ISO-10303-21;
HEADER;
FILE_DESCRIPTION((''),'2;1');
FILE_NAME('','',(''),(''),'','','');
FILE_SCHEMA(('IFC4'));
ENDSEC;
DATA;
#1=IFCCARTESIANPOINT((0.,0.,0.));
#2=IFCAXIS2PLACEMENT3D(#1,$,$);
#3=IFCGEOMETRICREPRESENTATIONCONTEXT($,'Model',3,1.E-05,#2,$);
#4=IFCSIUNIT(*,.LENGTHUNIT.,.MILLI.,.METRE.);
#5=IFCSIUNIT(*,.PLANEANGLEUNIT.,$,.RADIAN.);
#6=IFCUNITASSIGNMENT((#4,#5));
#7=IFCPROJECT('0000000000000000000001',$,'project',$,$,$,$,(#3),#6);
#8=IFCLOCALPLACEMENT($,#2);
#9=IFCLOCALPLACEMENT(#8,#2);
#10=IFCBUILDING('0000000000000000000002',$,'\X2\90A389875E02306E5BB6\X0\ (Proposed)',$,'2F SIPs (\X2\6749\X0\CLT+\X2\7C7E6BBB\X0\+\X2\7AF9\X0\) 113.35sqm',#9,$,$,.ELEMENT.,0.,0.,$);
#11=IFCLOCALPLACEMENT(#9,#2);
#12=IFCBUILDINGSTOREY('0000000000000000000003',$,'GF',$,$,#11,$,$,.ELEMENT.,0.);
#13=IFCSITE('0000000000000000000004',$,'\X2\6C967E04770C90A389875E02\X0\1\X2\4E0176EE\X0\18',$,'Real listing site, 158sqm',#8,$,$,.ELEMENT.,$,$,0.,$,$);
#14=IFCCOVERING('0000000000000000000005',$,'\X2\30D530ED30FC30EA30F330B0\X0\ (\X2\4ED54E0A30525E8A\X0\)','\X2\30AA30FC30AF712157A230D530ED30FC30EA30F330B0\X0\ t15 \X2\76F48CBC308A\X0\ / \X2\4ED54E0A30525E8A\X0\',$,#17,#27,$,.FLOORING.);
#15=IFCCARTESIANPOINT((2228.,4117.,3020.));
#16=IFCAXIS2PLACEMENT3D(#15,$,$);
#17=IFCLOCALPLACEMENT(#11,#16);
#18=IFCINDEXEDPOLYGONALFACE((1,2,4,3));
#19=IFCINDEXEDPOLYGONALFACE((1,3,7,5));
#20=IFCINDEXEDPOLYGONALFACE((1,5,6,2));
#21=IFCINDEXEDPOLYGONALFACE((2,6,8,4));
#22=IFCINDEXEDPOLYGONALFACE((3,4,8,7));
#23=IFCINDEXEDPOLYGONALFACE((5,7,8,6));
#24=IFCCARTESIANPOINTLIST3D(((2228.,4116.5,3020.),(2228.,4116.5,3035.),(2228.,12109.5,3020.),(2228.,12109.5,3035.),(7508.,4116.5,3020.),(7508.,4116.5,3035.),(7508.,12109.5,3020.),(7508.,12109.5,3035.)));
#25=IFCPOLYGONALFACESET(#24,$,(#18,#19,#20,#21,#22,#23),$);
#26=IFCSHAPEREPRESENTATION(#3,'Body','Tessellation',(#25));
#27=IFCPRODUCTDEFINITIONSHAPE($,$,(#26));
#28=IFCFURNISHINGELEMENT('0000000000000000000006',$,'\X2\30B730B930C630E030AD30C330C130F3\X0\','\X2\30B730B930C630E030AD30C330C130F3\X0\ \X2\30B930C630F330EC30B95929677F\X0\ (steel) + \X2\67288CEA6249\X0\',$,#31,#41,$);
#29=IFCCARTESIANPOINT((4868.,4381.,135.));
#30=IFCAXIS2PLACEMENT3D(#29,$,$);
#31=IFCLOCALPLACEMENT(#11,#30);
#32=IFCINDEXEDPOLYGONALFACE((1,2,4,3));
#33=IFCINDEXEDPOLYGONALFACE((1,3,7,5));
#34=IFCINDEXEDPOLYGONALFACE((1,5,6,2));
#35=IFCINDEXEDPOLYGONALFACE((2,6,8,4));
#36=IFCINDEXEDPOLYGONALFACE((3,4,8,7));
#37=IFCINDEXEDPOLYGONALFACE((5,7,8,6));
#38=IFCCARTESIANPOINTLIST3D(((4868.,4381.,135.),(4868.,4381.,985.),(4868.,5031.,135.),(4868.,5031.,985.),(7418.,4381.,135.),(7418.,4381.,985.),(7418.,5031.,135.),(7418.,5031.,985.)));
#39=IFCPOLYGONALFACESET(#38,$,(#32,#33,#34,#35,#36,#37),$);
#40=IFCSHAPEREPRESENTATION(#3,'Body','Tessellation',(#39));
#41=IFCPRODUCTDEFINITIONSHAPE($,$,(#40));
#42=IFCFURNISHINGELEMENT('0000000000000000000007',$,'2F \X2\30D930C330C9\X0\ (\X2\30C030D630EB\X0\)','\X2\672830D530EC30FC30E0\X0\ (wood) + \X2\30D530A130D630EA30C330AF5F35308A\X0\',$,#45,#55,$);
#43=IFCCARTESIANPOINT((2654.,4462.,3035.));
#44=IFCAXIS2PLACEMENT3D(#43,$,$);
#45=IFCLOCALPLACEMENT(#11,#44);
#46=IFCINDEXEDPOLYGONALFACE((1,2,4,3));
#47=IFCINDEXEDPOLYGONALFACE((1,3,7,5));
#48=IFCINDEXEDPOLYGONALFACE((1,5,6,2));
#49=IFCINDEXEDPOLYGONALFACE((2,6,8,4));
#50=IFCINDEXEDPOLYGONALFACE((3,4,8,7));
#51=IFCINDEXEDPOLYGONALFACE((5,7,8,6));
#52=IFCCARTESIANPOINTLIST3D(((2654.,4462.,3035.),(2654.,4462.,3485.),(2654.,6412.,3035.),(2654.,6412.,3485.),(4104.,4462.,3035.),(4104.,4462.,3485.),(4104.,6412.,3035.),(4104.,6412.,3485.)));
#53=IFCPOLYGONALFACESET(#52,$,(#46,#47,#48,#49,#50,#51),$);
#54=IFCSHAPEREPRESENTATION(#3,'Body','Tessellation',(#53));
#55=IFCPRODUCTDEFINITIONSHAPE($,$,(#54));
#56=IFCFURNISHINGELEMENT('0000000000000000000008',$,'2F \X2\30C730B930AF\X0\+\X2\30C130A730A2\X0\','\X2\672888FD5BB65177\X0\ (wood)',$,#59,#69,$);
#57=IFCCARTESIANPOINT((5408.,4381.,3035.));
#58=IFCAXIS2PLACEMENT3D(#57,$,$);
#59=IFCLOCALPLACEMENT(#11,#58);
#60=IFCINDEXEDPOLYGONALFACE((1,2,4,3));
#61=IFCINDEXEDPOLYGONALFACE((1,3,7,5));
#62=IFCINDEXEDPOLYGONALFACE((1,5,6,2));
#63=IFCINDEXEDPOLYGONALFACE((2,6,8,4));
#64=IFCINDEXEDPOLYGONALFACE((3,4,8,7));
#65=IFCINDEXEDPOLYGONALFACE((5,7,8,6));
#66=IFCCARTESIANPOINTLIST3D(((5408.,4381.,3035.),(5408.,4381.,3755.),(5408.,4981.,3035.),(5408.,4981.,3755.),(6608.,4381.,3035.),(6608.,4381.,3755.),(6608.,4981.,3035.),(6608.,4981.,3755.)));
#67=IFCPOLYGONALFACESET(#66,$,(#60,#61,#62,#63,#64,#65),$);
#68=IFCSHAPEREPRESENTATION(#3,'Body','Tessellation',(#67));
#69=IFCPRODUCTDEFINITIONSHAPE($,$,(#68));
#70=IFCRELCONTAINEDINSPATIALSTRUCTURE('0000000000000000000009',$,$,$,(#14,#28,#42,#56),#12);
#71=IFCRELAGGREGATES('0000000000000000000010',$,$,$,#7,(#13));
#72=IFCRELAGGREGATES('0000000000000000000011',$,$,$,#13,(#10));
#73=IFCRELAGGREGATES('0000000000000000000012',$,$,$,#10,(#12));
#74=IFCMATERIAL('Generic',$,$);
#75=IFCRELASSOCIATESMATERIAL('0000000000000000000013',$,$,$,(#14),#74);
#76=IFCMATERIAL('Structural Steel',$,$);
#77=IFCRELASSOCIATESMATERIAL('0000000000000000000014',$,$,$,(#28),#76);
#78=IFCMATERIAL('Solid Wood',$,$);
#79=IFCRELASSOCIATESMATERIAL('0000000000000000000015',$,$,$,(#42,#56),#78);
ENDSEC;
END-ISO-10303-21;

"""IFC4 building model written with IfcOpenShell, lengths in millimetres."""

from ifc_helpers import new_model, si_unit, frame, frame_2d, origin, place, context, project, spatial, rectangle, extrude, material, element, save


model = new_model("IFC4")

# Units and contexts
model_context = context("Model", 3, precision=1e-05, world=origin())
ifc_project = project(units=[si_unit("LENGTHUNIT", "METRE", prefix="MILLI"), si_unit("PLANEANGLEUNIT", "RADIAN")], contexts=[model_context])

# Site, building, storey
site_placement = place(None, origin())
site = spatial("IfcSite", under=ifc_project, at=site_placement, Name="沖縄県那覇市1丁目18", ObjectType="Real listing site, 158sqm", CompositionType="ELEMENT", RefElevation=0.0)
building_placement = place(site_placement, origin())
building = spatial("IfcBuilding", under=site, at=building_placement, Name="那覇市の家 (Proposed)", ObjectType="2F SIPs (杉CLT+籾殻+竹) 113.35sqm", CompositionType="ELEMENT", ElevationOfRefHeight=0.0, ElevationOfTerrain=0.0)
storey_placement = place(building_placement, origin())
storey = spatial("IfcBuildingStorey", under=building, at=storey_placement, Name="GF", CompositionType="ELEMENT", Elevation=0.0)

# Shared definitions
ifc_material_1 = material(Name="Solid Wood")

# Shared definitions
ifc_material_2 = material(Name="Generic")

# Shared definitions
ifc_material_3 = material(Name="Structural Steel")

# Covering
covering_placement = place(storey_placement, frame((2228.0, 4117.0, 3020.0)))
element("IfcCovering", 1, at=covering_placement, inside=storey, material=ifc_material_2, Name="フローリング (仕上げ床)", Description="オーク無垢フローリング t15 直貼り / 仕上げ床", PredefinedType="FLOORING", context=model_context, shape_type="SweptSolid", body=[
    extrude(rectangle(XDim=5280.0, YDim=7993.0, at=frame_2d((2640.0, 3996.0))), frame((2228.0, 4117.0, 3020.0)), (0.0, 0.0, 1.0), 15.0),
])

# Furnishing elements
furnishing_1_placement = place(storey_placement, frame((4868.0, 4381.0, 135.0)))
element("IfcFurnishingElement", 2, at=furnishing_1_placement, inside=storey, material=ifc_material_3, Name="システムキッチン", Description="システムキッチン ステンレス天板 (steel) + 木質扉", context=model_context, shape_type="SweptSolid", body=[
    extrude(rectangle(XDim=2550.0, YDim=650.0, at=frame_2d((1275.0, 325.0))), frame((4868.0, 4381.0, 135.0)), (0.0, 0.0, 1.0), 850.0),
])
furnishing_2_placement = place(storey_placement, frame((2654.0, 4462.0, 3035.0)))
element("IfcFurnishingElement", 3, at=furnishing_2_placement, inside=storey, material=ifc_material_1, Name="2F ベッド (ダブル)", Description="木フレーム (wood) + ファブリック張り", context=model_context, shape_type="SweptSolid", body=[
    extrude(rectangle(XDim=1450.0, YDim=1950.0, at=frame_2d((725.0, 975.0))), frame((2654.0, 4462.0, 3035.0)), (0.0, 0.0, 1.0), 450.0),
])
furnishing_3_placement = place(storey_placement, frame((5408.0, 4381.0, 3035.0)))
element("IfcFurnishingElement", 4, at=furnishing_3_placement, inside=storey, material=ifc_material_1, Name="2F デスク+チェア", Description="木製家具 (wood)", context=model_context, shape_type="SweptSolid", body=[
    extrude(rectangle(XDim=1200.0, YDim=600.0, at=frame_2d((600.0, 300.0))), frame((5408.0, 4381.0, 3035.0)), (0.0, 0.0, 1.0), 720.0),
])

save(model, "model.ifc")
